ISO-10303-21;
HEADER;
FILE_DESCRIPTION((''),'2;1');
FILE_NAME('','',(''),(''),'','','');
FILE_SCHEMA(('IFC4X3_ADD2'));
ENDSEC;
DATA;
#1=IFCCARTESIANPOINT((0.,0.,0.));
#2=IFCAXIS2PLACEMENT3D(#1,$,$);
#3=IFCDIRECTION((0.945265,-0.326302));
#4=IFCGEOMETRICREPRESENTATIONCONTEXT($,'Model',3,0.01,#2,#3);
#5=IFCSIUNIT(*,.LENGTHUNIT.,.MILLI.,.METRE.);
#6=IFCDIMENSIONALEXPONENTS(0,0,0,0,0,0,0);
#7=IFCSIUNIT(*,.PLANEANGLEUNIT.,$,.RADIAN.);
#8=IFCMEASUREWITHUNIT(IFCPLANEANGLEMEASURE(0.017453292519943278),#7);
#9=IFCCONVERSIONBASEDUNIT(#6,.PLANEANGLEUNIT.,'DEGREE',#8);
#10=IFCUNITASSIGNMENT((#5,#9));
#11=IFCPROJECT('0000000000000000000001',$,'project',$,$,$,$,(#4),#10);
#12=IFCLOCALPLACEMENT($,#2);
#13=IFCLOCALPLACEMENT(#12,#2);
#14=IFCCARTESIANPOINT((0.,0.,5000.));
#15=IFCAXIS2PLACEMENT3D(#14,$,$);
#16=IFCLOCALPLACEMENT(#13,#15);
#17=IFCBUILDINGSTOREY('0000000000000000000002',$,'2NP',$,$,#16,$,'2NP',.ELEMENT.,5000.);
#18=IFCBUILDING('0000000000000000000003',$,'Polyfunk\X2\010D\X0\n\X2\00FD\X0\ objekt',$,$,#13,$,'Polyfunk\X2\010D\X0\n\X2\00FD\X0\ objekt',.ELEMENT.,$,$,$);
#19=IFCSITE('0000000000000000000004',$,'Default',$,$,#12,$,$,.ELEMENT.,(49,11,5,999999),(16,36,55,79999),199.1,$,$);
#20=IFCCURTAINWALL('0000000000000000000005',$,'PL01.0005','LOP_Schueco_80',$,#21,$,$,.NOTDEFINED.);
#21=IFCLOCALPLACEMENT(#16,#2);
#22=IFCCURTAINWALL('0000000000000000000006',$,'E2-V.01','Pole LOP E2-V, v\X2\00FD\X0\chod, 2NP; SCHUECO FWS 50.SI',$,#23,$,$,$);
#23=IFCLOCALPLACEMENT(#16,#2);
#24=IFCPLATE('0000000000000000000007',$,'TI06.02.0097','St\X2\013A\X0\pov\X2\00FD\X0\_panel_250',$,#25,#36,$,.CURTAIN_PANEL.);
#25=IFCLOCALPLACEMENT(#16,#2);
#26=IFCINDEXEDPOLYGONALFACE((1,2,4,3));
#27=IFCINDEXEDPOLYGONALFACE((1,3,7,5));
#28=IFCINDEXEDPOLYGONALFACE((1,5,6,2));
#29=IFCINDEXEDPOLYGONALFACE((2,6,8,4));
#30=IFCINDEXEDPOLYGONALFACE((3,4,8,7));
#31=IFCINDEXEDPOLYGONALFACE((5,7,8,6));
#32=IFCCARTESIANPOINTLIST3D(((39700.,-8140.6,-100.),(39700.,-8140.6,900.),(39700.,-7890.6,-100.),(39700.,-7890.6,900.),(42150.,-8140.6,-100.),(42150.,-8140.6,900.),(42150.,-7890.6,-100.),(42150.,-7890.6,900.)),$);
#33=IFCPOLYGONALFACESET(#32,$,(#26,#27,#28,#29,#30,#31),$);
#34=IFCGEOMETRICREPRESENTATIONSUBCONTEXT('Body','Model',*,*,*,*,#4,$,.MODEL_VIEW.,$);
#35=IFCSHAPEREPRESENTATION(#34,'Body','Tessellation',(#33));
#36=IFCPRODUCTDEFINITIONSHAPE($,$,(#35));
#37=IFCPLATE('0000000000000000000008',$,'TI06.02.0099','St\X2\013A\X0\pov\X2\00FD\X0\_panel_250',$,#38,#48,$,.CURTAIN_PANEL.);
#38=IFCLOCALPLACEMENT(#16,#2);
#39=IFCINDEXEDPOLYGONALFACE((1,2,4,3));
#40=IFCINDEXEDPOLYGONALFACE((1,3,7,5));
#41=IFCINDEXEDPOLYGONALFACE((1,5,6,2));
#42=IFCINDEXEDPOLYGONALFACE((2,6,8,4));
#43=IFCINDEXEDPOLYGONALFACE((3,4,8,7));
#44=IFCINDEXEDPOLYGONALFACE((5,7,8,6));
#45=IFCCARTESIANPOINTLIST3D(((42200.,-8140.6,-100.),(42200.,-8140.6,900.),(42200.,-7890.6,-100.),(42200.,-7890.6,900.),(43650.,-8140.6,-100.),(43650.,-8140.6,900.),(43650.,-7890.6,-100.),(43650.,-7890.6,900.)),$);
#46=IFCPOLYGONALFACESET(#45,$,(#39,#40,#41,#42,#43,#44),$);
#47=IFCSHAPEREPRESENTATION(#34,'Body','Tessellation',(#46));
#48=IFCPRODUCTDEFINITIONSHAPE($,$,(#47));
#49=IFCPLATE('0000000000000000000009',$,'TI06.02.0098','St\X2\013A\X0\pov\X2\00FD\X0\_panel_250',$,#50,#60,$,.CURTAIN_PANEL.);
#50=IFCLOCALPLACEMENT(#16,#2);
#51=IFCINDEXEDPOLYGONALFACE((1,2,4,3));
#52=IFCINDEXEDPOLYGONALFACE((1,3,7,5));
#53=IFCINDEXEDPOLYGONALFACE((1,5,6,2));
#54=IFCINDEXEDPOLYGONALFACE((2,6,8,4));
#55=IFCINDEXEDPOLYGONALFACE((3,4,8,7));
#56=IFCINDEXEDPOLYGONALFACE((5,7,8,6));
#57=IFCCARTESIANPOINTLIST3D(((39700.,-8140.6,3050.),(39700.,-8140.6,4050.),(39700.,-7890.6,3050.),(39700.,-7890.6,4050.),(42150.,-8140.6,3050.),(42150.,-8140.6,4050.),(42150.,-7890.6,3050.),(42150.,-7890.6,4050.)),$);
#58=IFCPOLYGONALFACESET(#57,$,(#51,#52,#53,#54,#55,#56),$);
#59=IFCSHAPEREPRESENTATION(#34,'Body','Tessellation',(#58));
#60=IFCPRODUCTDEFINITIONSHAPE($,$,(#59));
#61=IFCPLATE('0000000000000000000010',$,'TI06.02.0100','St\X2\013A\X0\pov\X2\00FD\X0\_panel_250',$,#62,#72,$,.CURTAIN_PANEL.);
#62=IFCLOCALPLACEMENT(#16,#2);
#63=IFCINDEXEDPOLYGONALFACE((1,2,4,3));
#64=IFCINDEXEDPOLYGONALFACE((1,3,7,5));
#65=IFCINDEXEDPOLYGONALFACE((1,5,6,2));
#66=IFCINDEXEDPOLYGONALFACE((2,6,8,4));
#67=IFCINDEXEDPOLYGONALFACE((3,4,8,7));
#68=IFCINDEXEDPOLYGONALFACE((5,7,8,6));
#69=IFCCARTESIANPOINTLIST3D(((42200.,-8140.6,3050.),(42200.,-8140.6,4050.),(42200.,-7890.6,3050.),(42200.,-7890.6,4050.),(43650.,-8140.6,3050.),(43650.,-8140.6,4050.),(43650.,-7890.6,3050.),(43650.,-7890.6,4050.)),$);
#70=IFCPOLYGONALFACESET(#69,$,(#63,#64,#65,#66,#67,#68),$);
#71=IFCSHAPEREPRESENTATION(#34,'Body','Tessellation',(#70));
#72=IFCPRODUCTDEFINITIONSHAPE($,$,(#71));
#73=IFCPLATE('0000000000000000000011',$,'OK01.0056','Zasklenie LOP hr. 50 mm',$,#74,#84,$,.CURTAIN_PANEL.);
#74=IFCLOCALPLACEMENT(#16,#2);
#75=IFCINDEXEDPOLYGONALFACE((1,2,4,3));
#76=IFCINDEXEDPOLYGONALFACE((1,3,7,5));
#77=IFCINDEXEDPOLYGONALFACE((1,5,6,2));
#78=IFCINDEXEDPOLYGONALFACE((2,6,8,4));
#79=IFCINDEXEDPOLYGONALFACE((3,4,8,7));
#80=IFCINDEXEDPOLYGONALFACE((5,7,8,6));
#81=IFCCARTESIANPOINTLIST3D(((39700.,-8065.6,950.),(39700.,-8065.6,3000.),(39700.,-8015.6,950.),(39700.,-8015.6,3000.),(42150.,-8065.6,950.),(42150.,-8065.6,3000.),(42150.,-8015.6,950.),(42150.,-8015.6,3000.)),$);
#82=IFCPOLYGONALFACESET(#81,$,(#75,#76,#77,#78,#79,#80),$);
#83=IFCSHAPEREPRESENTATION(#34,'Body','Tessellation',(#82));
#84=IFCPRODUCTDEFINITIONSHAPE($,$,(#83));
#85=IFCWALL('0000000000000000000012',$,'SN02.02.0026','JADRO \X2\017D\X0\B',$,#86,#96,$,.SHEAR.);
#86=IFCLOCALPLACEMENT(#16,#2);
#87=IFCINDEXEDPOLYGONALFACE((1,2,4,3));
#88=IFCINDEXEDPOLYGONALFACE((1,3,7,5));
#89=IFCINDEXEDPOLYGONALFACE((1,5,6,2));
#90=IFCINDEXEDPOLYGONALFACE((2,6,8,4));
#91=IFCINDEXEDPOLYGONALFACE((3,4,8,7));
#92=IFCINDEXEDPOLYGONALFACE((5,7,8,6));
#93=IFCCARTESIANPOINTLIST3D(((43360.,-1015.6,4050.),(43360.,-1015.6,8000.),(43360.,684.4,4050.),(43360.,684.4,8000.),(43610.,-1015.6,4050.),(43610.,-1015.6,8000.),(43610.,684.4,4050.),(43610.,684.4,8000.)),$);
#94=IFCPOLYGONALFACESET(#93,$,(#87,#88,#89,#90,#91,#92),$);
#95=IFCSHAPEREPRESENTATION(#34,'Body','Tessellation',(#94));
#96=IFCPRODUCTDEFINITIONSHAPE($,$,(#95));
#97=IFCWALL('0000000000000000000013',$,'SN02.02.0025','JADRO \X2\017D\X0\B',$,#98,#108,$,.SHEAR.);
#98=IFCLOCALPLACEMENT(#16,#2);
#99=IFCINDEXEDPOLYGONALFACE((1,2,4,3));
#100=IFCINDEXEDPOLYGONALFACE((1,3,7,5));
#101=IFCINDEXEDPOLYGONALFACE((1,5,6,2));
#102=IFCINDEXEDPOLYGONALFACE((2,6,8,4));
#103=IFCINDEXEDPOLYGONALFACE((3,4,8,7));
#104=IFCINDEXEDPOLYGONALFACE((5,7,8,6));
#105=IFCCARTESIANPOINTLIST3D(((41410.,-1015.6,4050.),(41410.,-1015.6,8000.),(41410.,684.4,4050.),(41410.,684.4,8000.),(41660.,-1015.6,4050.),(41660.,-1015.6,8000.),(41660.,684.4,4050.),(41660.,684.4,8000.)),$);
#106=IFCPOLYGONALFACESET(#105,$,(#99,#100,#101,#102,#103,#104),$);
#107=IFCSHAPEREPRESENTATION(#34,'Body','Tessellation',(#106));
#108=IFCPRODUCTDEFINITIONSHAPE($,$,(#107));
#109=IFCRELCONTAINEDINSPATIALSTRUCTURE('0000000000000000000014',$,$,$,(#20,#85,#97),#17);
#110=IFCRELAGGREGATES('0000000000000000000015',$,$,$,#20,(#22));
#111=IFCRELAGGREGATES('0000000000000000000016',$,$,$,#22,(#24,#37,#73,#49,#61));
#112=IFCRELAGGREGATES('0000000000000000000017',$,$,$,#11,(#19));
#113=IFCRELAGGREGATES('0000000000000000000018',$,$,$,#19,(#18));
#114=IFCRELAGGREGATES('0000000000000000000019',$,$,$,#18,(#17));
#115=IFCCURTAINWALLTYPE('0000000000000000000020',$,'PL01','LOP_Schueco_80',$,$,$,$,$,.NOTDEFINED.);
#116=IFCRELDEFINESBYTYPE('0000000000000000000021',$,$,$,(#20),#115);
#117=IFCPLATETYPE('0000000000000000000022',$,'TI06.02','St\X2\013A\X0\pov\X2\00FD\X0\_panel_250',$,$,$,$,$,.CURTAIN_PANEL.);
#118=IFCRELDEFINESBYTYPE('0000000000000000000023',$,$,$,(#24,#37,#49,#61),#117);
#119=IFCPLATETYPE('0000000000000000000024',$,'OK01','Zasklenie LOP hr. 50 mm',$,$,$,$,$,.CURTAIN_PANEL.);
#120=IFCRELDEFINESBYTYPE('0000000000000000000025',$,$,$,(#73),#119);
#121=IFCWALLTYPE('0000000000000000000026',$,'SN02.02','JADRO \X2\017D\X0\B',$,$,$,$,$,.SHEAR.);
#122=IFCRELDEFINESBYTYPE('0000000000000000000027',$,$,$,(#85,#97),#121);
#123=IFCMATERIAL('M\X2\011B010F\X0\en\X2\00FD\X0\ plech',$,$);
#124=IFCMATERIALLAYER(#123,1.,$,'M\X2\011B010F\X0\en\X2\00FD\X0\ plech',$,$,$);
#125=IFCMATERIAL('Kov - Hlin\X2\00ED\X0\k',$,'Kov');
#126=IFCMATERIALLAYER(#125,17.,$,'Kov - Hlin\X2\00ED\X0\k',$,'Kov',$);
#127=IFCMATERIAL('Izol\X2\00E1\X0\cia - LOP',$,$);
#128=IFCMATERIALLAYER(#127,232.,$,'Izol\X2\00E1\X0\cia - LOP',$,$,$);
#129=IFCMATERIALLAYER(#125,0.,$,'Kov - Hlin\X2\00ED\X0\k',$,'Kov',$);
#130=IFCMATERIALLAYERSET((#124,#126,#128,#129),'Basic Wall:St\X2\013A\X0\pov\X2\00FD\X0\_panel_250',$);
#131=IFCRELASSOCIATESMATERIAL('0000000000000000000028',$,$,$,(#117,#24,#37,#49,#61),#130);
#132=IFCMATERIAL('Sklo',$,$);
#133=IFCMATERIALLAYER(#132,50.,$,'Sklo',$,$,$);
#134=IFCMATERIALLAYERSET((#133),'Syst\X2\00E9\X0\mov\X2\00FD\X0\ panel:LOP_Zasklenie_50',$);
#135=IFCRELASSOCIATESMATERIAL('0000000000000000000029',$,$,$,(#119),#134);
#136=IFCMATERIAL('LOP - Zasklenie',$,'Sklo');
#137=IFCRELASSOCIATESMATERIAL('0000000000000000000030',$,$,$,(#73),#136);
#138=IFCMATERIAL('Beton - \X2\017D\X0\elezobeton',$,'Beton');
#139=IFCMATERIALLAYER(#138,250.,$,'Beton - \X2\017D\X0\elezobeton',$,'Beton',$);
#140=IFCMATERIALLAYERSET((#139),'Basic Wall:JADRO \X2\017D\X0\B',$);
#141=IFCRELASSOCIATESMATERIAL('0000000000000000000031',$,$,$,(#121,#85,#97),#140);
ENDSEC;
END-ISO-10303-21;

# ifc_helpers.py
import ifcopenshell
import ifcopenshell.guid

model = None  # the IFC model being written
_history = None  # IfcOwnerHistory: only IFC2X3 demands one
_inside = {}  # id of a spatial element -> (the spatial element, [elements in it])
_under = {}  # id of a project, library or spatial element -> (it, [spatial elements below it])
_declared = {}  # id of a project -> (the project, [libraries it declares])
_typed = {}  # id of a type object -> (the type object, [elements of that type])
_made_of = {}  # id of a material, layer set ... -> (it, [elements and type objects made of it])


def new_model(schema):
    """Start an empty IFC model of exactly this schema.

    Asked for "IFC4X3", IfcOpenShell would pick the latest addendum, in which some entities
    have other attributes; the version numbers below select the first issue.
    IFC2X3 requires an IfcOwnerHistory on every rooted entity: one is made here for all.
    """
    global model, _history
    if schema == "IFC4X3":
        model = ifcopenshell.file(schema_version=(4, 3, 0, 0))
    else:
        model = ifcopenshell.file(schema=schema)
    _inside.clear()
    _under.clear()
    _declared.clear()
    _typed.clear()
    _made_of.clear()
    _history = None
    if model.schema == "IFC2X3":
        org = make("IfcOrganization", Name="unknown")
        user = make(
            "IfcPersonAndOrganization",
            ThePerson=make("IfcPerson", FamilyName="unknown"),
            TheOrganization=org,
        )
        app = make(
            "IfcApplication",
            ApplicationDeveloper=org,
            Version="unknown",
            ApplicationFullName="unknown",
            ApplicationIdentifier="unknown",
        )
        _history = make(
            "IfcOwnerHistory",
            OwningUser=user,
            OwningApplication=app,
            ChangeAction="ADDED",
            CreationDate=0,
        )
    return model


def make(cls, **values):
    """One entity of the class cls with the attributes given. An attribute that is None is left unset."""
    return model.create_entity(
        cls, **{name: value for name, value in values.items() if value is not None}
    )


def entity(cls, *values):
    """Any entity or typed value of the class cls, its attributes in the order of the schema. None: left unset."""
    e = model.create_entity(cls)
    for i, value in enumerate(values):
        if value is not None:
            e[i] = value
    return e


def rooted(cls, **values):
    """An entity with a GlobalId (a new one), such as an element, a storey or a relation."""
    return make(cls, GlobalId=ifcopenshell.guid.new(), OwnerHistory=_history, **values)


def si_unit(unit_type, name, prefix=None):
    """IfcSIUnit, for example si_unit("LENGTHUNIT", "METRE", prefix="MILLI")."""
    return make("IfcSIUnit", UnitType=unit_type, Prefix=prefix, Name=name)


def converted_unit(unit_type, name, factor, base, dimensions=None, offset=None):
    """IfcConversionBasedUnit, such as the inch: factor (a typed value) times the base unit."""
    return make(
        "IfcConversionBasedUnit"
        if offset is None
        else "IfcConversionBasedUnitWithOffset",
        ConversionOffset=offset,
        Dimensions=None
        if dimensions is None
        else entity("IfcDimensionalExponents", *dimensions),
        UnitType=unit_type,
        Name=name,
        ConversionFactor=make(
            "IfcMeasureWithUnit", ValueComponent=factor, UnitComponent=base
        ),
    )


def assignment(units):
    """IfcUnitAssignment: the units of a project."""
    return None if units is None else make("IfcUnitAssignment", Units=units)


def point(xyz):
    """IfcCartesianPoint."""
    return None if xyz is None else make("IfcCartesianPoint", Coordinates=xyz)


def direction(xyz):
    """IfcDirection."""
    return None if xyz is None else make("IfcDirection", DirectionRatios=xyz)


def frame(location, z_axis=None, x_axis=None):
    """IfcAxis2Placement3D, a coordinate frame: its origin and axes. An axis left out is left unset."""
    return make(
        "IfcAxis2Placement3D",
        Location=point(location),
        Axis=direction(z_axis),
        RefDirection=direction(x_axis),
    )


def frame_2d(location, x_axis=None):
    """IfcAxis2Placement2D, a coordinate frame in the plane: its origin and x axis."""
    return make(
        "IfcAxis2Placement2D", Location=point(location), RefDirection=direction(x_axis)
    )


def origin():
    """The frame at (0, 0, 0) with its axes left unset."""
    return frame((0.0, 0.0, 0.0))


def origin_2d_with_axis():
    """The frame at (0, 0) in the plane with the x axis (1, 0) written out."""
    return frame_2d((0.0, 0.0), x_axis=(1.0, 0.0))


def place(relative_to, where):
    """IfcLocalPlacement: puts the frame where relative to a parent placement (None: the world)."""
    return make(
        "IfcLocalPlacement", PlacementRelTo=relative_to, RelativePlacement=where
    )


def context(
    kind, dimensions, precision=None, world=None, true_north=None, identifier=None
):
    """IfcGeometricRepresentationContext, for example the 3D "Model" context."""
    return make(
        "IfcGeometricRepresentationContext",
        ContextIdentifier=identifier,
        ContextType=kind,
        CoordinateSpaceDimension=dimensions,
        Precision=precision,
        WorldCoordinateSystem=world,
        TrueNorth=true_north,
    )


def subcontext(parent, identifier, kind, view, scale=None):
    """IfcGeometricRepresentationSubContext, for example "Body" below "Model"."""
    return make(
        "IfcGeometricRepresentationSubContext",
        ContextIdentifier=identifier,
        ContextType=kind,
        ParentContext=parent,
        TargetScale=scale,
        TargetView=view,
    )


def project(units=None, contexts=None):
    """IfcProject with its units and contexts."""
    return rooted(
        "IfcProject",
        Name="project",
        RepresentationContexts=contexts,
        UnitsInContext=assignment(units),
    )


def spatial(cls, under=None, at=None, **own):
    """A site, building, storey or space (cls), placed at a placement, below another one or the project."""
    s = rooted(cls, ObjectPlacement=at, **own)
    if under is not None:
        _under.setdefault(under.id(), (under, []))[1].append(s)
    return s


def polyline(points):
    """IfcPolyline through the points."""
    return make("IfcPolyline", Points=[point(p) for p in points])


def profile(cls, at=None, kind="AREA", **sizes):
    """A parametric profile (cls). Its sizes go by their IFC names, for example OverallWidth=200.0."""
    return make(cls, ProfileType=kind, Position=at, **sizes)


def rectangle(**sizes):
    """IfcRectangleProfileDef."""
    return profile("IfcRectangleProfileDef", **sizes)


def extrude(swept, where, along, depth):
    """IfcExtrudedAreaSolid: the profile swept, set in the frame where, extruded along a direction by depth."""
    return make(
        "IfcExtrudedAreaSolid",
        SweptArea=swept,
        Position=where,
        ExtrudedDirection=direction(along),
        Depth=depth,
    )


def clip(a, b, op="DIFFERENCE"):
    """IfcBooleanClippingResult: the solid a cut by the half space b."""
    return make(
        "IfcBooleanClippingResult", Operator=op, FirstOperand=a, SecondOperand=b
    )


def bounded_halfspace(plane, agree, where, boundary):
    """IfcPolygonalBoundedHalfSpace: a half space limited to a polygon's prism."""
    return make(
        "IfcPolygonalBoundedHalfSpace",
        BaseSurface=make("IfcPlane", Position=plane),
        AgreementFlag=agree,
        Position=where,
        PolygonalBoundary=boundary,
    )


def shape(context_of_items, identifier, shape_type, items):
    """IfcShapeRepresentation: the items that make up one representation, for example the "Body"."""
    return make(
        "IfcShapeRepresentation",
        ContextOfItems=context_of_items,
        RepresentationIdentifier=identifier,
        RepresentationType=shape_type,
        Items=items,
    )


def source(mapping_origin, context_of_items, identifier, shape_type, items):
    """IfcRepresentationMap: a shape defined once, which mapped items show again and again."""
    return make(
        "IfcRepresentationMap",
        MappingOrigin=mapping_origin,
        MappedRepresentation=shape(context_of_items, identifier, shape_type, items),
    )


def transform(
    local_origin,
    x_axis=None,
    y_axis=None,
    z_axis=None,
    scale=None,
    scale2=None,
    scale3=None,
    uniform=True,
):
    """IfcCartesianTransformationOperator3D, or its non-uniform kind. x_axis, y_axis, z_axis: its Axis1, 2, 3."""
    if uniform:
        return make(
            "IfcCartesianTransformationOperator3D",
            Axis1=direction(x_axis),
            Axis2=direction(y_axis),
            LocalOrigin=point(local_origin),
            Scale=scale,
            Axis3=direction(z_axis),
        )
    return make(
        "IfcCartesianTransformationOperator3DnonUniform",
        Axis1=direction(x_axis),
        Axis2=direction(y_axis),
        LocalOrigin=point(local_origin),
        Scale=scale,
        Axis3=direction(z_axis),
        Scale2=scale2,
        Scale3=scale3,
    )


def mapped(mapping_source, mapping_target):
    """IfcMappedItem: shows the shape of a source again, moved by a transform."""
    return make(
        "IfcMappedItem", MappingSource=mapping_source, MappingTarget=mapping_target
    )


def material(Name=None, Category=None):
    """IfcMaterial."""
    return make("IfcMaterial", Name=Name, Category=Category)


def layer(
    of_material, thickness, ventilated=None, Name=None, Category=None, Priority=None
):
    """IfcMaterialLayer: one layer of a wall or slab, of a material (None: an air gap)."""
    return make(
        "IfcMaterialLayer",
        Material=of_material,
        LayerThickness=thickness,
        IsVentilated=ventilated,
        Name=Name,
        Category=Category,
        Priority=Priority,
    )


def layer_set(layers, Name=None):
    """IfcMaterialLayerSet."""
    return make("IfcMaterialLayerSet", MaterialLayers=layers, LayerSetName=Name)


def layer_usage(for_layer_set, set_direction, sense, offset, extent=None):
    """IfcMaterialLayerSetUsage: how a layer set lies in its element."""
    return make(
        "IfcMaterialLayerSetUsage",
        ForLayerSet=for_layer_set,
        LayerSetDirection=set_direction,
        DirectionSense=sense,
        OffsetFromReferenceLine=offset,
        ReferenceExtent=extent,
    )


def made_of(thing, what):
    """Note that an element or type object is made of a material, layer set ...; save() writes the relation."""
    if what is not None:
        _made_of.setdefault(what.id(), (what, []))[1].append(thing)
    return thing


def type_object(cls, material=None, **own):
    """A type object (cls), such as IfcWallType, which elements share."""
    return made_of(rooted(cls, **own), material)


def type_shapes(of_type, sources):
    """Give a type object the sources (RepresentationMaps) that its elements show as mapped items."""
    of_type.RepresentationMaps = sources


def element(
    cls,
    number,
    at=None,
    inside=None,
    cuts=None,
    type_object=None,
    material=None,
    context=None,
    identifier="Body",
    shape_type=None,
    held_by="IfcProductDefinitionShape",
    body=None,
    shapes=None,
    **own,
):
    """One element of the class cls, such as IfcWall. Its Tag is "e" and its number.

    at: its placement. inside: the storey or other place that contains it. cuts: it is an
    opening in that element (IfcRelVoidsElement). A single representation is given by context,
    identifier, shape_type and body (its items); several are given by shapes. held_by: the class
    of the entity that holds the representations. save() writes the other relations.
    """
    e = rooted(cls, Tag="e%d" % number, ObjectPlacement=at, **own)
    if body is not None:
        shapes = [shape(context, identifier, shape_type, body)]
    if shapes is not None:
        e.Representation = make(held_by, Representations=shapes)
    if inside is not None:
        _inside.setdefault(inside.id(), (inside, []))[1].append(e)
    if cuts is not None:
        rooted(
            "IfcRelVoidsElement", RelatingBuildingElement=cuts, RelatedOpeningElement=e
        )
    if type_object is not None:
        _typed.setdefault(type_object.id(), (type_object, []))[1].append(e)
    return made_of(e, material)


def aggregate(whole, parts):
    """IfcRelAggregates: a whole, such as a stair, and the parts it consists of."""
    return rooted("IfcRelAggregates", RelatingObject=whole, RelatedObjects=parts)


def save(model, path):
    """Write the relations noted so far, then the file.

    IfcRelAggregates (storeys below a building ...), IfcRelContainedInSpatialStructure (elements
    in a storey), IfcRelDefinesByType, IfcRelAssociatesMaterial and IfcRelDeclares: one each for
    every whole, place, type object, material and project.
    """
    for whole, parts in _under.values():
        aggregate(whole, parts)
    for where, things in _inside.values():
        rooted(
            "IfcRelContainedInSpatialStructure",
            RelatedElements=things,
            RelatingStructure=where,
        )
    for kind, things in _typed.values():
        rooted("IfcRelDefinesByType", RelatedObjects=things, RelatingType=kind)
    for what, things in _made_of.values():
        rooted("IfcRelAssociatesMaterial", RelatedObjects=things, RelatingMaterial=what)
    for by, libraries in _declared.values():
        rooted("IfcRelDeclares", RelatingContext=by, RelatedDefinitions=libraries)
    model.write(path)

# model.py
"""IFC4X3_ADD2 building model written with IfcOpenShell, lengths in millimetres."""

from ifc_helpers import new_model, entity, si_unit, converted_unit, direction, frame, frame_2d, origin, origin_2d_with_axis, place, context, subcontext, project, spatial, polyline, rectangle, extrude, clip, bounded_halfspace, source, transform, mapped, material, layer, layer_set, layer_usage, type_object, type_shapes, element, aggregate, save


model = new_model("IFC4X3_ADD2")

# Units and contexts
model_context = context("Model", 3, precision=0.01, world=origin(), true_north=direction((0.945265, -0.326302)))
body_context = subcontext(model_context, "Body", "Model", "MODEL_VIEW")
ifc_project = project(units=[si_unit("LENGTHUNIT", "METRE", prefix="MILLI"), converted_unit("PLANEANGLEUNIT", "DEGREE", entity("IfcPlaneAngleMeasure", 0.017453292519943278), si_unit("PLANEANGLEUNIT", "RADIAN"), dimensions=[0, 0, 0, 0, 0, 0, 0])], contexts=[model_context])

# Site, building, storey
site_placement = place(None, origin())
site = spatial("IfcSite", under=ifc_project, at=site_placement, Name="Default", CompositionType="ELEMENT", RefLatitude=(49, 11, 5, 999999), RefLongitude=(16, 36, 55, 79999), RefElevation=199.1)
building_placement = place(site_placement, origin())
building = spatial("IfcBuilding", under=site, at=building_placement, Name="Polyfunkčný objekt", LongName="Polyfunkčný objekt", CompositionType="ELEMENT")
storey_placement = place(building_placement, frame((0.0, 0.0, 5000.0)))
storey = spatial("IfcBuildingStorey", under=building, at=storey_placement, Name="2NP", LongName="2NP", CompositionType="ELEMENT", Elevation=5000.0)

# Curtain walls, plates
curtain_wall_type = type_object("IfcCurtainWallType", Name="PL01", Description="LOP_Schueco_80", PredefinedType="NOTDEFINED")
curtain_wall_1_placement = place(storey_placement, frame((0.0, 0.0, -5000.0)))
curtain_wall_1 = element("IfcCurtainWall", 1, at=curtain_wall_1_placement, inside=storey, type_object=curtain_wall_type, Name="PL01.0005", Description="LOP_Schueco_80", PredefinedType="NOTDEFINED")
curtain_wall_2 = element("IfcCurtainWall", 2, Name="E2-V.01", Description="Pole LOP E2-V, východ, 2NP; SCHUECO FWS 50.SI")
aggregate(curtain_wall_1, [curtain_wall_2])
ifc_material_1 = material(Name="Měďený plech")
ifc_layer_1 = layer(ifc_material_1, 1.0, Name="Měďený plech")
ifc_material_2 = material(Name="Kov - Hliník", Category="Kov")
ifc_layer_2 = layer(ifc_material_2, 17.0, Name="Kov - Hliník", Category="Kov")
ifc_material_3 = material(Name="Izolácia - LOP")
ifc_layer_3 = layer(ifc_material_3, 232.0, Name="Izolácia - LOP")
ifc_layer_4 = layer(ifc_material_2, 0.0, Name="Kov - Hliník", Category="Kov")
ifc_layer_set_1 = layer_set([ifc_layer_1, ifc_layer_2, ifc_layer_3, ifc_layer_4], Name="Basic Wall:Stĺpový_panel_250")
ifc_layer_usage_1 = layer_usage(ifc_layer_set_1, "AXIS2", "POSITIVE", -125.0)
plate_type_1 = type_object("IfcPlateType", Name="TI06.02", Description="Stĺpový_panel_250", PredefinedType="CURTAIN_PANEL", material=ifc_layer_set_1)
plate_1_placement = place(storey_placement, frame((39700.0, -8015.6, -100.0)))
plate_1 = element("IfcPlate", 3, at=plate_1_placement, type_object=plate_type_1, material=ifc_layer_usage_1, Name="TI06.02.0097", Description="Stĺpový_panel_250", PredefinedType="CURTAIN_PANEL", context=body_context, shape_type="SweptSolid", body=[
    extrude(rectangle(XDim=250.0, YDim=2450.0, at=frame_2d((0.0, 0.0), x_axis=(1.0, 0.0))), frame((1225.0, 0.0, 0.0), z_axis=(0.0, 0.0, 1.0), x_axis=(0.0, 1.0, 0.0)), (0.0, 0.0, 1.0), 1000.0),
])
ifc_layer_usage_2 = layer_usage(ifc_layer_set_1, "AXIS2", "POSITIVE", -125.0)
plate_2_placement = place(storey_placement, frame((42200.0, -8015.6, -100.0)))
plate_2 = element("IfcPlate", 4, at=plate_2_placement, type_object=plate_type_1, material=ifc_layer_usage_2, Name="TI06.02.0099", Description="Stĺpový_panel_250", PredefinedType="CURTAIN_PANEL", context=body_context, shape_type="SweptSolid", body=[
    extrude(rectangle(XDim=250.0, YDim=1450.0, at=frame_2d((0.0, 0.0), x_axis=(1.0, 0.0))), frame((725.0, 0.0, 0.0), z_axis=(0.0, 0.0, 1.0), x_axis=(0.0, 1.0, 0.0)), (0.0, 0.0, 1.0), 1000.0),
])
ifc_layer_usage_3 = layer_usage(ifc_layer_set_1, "AXIS2", "POSITIVE", -125.0)
plate_3_placement = place(storey_placement, frame((39700.0, -8015.6, 3050.0)))
plate_3 = element("IfcPlate", 5, at=plate_3_placement, type_object=plate_type_1, material=ifc_layer_usage_3, Name="TI06.02.0098", Description="Stĺpový_panel_250", PredefinedType="CURTAIN_PANEL", context=body_context, shape_type="SweptSolid", body=[
    extrude(rectangle(XDim=250.0, YDim=2450.0, at=frame_2d((0.0, 0.0), x_axis=(1.0, 0.0))), frame((1225.0, 0.0, 0.0), z_axis=(0.0, 0.0, 1.0), x_axis=(0.0, 1.0, 0.0)), (0.0, 0.0, 1.0), 1000.0),
])
ifc_layer_usage_4 = layer_usage(ifc_layer_set_1, "AXIS2", "POSITIVE", -125.0)
plate_4_placement = place(storey_placement, frame((42200.0, -8015.6, 3050.0)))
plate_4 = element("IfcPlate", 6, at=plate_4_placement, type_object=plate_type_1, material=ifc_layer_usage_4, Name="TI06.02.0100", Description="Stĺpový_panel_250", PredefinedType="CURTAIN_PANEL", context=body_context, shape_type="SweptSolid", body=[
    extrude(rectangle(XDim=250.0, YDim=1450.0, at=frame_2d((0.0, 0.0), x_axis=(1.0, 0.0))), frame((725.0, 0.0, 0.0), z_axis=(0.0, 0.0, 1.0), x_axis=(0.0, 1.0, 0.0)), (0.0, 0.0, 1.0), 1000.0),
])
ifc_material_4 = material(Name="LOP - Zasklenie", Category="Sklo")
ifc_material_5 = material(Name="Sklo")
ifc_layer_5 = layer(ifc_material_5, 50.0, Name="Sklo")
ifc_layer_set_2 = layer_set([ifc_layer_5], Name="Systémový panel:LOP_Zasklenie_50")
plate_type_2 = type_object("IfcPlateType", Name="OK01", Description="Zasklenie LOP hr. 50 mm", PredefinedType="CURTAIN_PANEL", material=ifc_layer_set_2)
shared_shape_1 = source(origin(), body_context, "Body", "SweptSolid", [
    extrude(rectangle(XDim=50.0, YDim=2450.0, at=origin_2d_with_axis()), frame((0.0, -25.0, 0.0), z_axis=(0.0, 0.0, 1.0), x_axis=(0.0, 1.0, 0.0)), (0.0, 0.0, 1.0), 2050.0),
])
type_shapes(plate_type_2, [shared_shape_1])
plate_5_placement = place(curtain_wall_1_placement, frame((40925.0, -8015.6, 5950.0)))
plate_5 = element("IfcPlate", 7, at=plate_5_placement, type_object=plate_type_2, material=ifc_material_4, Name="OK01.0056", Description="Zasklenie LOP hr. 50 mm", PredefinedType="CURTAIN_PANEL", context=body_context, shape_type="MappedRepresentation", body=[
    mapped(shared_shape_1, transform((0.0, 0.0, 0.0), scale=1.0)),
])
aggregate(curtain_wall_2, [plate_1, plate_2, plate_5, plate_3, plate_4])

# Walls
ifc_material_6 = material(Name="Beton - Železobeton", Category="Beton")
ifc_layer_6 = layer(ifc_material_6, 250.0, Name="Beton - Železobeton", Category="Beton")
ifc_layer_set_3 = layer_set([ifc_layer_6], Name="Basic Wall:JADRO ŽB")
wall_type = type_object("IfcWallType", Name="SN02.02", Description="JADRO ŽB", PredefinedType="SHEAR", material=ifc_layer_set_3)
wall_1_placement = place(storey_placement, frame((43485.0, 684.4, 4050.0), z_axis=(0.0, 0.0, 1.0), x_axis=(0.0, -1.0, 0.0)))
element("IfcWall", 8, at=wall_1_placement, inside=storey, type_object=wall_type, material=ifc_layer_set_3, Name="SN02.02.0026", Description="JADRO ŽB", PredefinedType="SHEAR", context=body_context, shape_type="Clipping", body=[
    clip(clip(extrude(rectangle(XDim=1700.0, YDim=250.0, at=frame_2d((850.0, 0.0), x_axis=(-1.0, 0.0))), origin(), (0.0, 0.0, 1.0), 3950.0), bounded_halfspace(frame((1700.0, -125.0, 0.0), z_axis=(0.0, 0.0, 1.0), x_axis=(0.0, -1.0, 0.0)), True, frame((1700.0, -125.0, 0.0)), polyline([(0.0, 0.0), (0.0, 250.0), (-1700.0, 250.0), (-1700.0, 0.0), (0.0, 0.0)]))), bounded_halfspace(frame((0.0, -125.0, 3950.0), z_axis=(0.0, 0.0, -1.0), x_axis=(0.0, 1.0, 0.0)), True, frame((0.0, -125.0, 3950.0)), polyline([(0.0, 0.0), (1700.0, 0.0), (1700.0, 250.0), (0.0, 250.0), (0.0, 0.0)]))),
])
wall_2_placement = place(storey_placement, frame((41535.0, 684.4, 4050.0), z_axis=(0.0, 0.0, 1.0), x_axis=(0.0, -1.0, 0.0)))
element("IfcWall", 9, at=wall_2_placement, inside=storey, type_object=wall_type, material=ifc_layer_set_3, Name="SN02.02.0025", Description="JADRO ŽB", PredefinedType="SHEAR", context=body_context, shape_type="Clipping", body=[
    clip(clip(extrude(rectangle(XDim=1700.0, YDim=250.0, at=frame_2d((850.0, 0.0), x_axis=(-1.0, 0.0))), origin(), (0.0, 0.0, 1.0), 3950.0), bounded_halfspace(frame((1700.0, -125.0, 0.0), z_axis=(0.0, 0.0, 1.0), x_axis=(0.0, -1.0, 0.0)), True, frame((1700.0, -125.0, 0.0)), polyline([(0.0, 0.0), (0.0, 250.0), (-1700.0, 250.0), (-1700.0, 0.0), (0.0, 0.0)]))), bounded_halfspace(frame((0.0, -125.0, 3950.0), z_axis=(0.0, 0.0, -1.0), x_axis=(0.0, 1.0, 0.0)), True, frame((0.0, -125.0, 3950.0)), polyline([(0.0, 0.0), (1700.0, 0.0), (1700.0, 250.0), (0.0, 250.0), (0.0, 0.0)]))),
])

save(model, "model.ifc")
